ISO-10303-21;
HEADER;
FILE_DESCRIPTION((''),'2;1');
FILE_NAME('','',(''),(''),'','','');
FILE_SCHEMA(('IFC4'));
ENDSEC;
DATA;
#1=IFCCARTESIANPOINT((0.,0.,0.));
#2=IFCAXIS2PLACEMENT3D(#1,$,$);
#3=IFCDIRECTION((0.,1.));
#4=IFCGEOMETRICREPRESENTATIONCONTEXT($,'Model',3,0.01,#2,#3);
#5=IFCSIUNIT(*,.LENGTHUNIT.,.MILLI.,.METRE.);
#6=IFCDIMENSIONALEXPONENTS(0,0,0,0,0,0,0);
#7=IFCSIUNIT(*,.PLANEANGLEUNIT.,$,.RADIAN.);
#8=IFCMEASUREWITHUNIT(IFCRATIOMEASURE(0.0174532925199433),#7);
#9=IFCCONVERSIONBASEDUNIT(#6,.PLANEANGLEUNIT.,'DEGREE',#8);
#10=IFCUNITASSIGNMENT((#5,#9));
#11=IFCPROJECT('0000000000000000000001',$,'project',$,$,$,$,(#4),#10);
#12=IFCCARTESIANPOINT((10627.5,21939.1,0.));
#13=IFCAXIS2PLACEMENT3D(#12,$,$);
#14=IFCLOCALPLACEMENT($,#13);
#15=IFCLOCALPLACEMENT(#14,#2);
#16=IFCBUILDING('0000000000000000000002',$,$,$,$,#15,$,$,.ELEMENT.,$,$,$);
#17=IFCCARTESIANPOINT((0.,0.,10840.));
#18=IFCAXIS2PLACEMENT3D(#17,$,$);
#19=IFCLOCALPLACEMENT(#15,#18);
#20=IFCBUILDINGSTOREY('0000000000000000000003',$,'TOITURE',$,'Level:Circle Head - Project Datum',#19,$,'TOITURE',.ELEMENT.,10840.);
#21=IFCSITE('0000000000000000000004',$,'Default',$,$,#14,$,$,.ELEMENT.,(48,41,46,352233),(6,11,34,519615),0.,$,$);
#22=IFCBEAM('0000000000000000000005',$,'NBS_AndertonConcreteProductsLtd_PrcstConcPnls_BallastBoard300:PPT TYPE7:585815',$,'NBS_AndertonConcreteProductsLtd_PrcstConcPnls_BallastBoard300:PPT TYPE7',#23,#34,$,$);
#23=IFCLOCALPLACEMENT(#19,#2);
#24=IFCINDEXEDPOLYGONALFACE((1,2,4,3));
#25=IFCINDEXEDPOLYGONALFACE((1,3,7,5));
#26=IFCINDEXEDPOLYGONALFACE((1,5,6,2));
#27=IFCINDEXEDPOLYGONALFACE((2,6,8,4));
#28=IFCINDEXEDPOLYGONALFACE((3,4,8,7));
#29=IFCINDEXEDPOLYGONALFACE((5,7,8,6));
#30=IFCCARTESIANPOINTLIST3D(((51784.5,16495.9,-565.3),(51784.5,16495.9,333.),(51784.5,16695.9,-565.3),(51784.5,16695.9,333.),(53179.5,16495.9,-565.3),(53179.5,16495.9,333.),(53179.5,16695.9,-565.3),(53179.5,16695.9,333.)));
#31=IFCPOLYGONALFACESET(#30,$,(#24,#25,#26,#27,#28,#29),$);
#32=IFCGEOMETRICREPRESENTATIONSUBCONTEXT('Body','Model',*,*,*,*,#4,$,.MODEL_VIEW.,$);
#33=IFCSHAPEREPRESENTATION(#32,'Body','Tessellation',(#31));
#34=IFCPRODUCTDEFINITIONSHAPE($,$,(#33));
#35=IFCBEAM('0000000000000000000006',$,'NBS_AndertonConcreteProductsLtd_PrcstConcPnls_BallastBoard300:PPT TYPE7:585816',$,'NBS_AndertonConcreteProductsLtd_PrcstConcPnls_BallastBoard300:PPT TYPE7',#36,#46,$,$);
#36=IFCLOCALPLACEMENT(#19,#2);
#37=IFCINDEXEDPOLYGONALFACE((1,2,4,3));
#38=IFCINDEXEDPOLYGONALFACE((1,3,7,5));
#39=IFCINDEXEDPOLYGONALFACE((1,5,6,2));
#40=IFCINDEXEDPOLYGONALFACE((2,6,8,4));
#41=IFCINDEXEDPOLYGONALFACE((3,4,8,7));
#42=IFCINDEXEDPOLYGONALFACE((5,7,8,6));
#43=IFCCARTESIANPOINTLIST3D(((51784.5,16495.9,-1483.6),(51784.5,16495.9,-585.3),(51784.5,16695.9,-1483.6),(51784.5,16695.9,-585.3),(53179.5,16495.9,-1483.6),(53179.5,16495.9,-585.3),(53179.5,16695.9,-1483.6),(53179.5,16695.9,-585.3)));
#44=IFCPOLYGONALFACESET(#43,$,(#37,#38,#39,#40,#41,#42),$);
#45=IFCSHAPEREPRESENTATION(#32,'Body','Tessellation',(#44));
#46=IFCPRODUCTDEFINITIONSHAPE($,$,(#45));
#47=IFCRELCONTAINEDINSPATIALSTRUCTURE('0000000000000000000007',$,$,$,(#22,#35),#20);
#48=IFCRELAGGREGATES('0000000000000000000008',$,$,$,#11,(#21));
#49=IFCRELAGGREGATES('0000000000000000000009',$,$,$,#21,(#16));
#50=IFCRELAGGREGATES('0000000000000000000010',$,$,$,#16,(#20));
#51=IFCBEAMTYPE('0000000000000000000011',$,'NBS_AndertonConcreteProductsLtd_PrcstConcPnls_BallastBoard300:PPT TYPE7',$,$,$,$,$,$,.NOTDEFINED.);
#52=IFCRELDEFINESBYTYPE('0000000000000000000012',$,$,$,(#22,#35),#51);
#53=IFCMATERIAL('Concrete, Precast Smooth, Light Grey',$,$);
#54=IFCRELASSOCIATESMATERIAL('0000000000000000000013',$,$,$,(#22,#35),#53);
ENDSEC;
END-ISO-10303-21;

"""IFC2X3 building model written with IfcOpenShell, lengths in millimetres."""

from ifc_helpers import new_model, entity, si_unit, converted_unit, direction, frame, frame_2d, origin, place, context, subcontext, project, spatial, rectangle, extrude, material, type_object, element, save


model = new_model("IFC2X3")

# Units and contexts
model_context = context("Model", 3, precision=0.01, world=origin(), true_north=direction((0.0, 1.0)))
body_context = subcontext(model_context, "Body", "Model", "MODEL_VIEW")
ifc_project = project(units=[si_unit("LENGTHUNIT", "METRE", prefix="MILLI"), converted_unit("PLANEANGLEUNIT", "DEGREE", entity("IfcRatioMeasure", 0.0174532925199433), si_unit("PLANEANGLEUNIT", "RADIAN"), dimensions=[0, 0, 0, 0, 0, 0, 0])], contexts=[model_context])

# Site, building, storey
site_placement = place(None, frame((10627.5, 21939.1, 0.0)))
site = spatial("IfcSite", under=ifc_project, at=site_placement, Name="Default", CompositionType="ELEMENT", RefLatitude=(48, 41, 46, 352233), RefLongitude=(6, 11, 34, 519615), RefElevation=0.0)
building_placement = place(site_placement, origin())
building = spatial("IfcBuilding", under=site, at=building_placement, CompositionType="ELEMENT")
storey_placement = place(building_placement, frame((0.0, 0.0, 10840.0)))
storey = spatial("IfcBuildingStorey", under=building, at=storey_placement, Name="TOITURE", ObjectType="Level:Circle Head - Project Datum", LongName="TOITURE", CompositionType="ELEMENT", Elevation=10840.0)

# Beams
ifc_material = material(Name="Concrete, Precast Smooth, Light Grey")
beam_type = type_object("IfcBeamType", Name="NBS_AndertonConcreteProductsLtd_PrcstConcPnls_BallastBoard300:PPT TYPE7", PredefinedType="NOTDEFINED")
beam_1_placement = place(storey_placement, origin())
element("IfcBeam", 1, at=beam_1_placement, inside=storey, type_object=beam_type, material=ifc_material, Name="NBS_AndertonConcreteProductsLtd_PrcstConcPnls_BallastBoard300:PPT TYPE7:585815", ObjectType="NBS_AndertonConcreteProductsLtd_PrcstConcPnls_BallastBoard300:PPT TYPE7", context=body_context, shape_type="SweptSolid", body=[
    extrude(rectangle(XDim=898.3, YDim=200.0, at=frame_2d((0.0, 0.0), x_axis=(1.0, 0.0))), frame((51784.5, 16595.9, -116.1), z_axis=(1.0, 0.0, 0.0), x_axis=(0.0, 0.0, -1.0)), (0.0, 0.0, 1.0), 1395.0),
])
beam_2_placement = place(storey_placement, origin())
element("IfcBeam", 2, at=beam_2_placement, inside=storey, type_object=beam_type, material=ifc_material, Name="NBS_AndertonConcreteProductsLtd_PrcstConcPnls_BallastBoard300:PPT TYPE7:585816", ObjectType="NBS_AndertonConcreteProductsLtd_PrcstConcPnls_BallastBoard300:PPT TYPE7", context=body_context, shape_type="SweptSolid", body=[
    extrude(rectangle(XDim=898.3, YDim=200.0, at=frame_2d((0.0, 0.0), x_axis=(1.0, 0.0))), frame((51784.5, 16595.9, -1034.4), z_axis=(1.0, 0.0, 0.0), x_axis=(0.0, 0.0, -1.0)), (0.0, 0.0, 1.0), 1395.0),
])

save(model, "model.ifc")
